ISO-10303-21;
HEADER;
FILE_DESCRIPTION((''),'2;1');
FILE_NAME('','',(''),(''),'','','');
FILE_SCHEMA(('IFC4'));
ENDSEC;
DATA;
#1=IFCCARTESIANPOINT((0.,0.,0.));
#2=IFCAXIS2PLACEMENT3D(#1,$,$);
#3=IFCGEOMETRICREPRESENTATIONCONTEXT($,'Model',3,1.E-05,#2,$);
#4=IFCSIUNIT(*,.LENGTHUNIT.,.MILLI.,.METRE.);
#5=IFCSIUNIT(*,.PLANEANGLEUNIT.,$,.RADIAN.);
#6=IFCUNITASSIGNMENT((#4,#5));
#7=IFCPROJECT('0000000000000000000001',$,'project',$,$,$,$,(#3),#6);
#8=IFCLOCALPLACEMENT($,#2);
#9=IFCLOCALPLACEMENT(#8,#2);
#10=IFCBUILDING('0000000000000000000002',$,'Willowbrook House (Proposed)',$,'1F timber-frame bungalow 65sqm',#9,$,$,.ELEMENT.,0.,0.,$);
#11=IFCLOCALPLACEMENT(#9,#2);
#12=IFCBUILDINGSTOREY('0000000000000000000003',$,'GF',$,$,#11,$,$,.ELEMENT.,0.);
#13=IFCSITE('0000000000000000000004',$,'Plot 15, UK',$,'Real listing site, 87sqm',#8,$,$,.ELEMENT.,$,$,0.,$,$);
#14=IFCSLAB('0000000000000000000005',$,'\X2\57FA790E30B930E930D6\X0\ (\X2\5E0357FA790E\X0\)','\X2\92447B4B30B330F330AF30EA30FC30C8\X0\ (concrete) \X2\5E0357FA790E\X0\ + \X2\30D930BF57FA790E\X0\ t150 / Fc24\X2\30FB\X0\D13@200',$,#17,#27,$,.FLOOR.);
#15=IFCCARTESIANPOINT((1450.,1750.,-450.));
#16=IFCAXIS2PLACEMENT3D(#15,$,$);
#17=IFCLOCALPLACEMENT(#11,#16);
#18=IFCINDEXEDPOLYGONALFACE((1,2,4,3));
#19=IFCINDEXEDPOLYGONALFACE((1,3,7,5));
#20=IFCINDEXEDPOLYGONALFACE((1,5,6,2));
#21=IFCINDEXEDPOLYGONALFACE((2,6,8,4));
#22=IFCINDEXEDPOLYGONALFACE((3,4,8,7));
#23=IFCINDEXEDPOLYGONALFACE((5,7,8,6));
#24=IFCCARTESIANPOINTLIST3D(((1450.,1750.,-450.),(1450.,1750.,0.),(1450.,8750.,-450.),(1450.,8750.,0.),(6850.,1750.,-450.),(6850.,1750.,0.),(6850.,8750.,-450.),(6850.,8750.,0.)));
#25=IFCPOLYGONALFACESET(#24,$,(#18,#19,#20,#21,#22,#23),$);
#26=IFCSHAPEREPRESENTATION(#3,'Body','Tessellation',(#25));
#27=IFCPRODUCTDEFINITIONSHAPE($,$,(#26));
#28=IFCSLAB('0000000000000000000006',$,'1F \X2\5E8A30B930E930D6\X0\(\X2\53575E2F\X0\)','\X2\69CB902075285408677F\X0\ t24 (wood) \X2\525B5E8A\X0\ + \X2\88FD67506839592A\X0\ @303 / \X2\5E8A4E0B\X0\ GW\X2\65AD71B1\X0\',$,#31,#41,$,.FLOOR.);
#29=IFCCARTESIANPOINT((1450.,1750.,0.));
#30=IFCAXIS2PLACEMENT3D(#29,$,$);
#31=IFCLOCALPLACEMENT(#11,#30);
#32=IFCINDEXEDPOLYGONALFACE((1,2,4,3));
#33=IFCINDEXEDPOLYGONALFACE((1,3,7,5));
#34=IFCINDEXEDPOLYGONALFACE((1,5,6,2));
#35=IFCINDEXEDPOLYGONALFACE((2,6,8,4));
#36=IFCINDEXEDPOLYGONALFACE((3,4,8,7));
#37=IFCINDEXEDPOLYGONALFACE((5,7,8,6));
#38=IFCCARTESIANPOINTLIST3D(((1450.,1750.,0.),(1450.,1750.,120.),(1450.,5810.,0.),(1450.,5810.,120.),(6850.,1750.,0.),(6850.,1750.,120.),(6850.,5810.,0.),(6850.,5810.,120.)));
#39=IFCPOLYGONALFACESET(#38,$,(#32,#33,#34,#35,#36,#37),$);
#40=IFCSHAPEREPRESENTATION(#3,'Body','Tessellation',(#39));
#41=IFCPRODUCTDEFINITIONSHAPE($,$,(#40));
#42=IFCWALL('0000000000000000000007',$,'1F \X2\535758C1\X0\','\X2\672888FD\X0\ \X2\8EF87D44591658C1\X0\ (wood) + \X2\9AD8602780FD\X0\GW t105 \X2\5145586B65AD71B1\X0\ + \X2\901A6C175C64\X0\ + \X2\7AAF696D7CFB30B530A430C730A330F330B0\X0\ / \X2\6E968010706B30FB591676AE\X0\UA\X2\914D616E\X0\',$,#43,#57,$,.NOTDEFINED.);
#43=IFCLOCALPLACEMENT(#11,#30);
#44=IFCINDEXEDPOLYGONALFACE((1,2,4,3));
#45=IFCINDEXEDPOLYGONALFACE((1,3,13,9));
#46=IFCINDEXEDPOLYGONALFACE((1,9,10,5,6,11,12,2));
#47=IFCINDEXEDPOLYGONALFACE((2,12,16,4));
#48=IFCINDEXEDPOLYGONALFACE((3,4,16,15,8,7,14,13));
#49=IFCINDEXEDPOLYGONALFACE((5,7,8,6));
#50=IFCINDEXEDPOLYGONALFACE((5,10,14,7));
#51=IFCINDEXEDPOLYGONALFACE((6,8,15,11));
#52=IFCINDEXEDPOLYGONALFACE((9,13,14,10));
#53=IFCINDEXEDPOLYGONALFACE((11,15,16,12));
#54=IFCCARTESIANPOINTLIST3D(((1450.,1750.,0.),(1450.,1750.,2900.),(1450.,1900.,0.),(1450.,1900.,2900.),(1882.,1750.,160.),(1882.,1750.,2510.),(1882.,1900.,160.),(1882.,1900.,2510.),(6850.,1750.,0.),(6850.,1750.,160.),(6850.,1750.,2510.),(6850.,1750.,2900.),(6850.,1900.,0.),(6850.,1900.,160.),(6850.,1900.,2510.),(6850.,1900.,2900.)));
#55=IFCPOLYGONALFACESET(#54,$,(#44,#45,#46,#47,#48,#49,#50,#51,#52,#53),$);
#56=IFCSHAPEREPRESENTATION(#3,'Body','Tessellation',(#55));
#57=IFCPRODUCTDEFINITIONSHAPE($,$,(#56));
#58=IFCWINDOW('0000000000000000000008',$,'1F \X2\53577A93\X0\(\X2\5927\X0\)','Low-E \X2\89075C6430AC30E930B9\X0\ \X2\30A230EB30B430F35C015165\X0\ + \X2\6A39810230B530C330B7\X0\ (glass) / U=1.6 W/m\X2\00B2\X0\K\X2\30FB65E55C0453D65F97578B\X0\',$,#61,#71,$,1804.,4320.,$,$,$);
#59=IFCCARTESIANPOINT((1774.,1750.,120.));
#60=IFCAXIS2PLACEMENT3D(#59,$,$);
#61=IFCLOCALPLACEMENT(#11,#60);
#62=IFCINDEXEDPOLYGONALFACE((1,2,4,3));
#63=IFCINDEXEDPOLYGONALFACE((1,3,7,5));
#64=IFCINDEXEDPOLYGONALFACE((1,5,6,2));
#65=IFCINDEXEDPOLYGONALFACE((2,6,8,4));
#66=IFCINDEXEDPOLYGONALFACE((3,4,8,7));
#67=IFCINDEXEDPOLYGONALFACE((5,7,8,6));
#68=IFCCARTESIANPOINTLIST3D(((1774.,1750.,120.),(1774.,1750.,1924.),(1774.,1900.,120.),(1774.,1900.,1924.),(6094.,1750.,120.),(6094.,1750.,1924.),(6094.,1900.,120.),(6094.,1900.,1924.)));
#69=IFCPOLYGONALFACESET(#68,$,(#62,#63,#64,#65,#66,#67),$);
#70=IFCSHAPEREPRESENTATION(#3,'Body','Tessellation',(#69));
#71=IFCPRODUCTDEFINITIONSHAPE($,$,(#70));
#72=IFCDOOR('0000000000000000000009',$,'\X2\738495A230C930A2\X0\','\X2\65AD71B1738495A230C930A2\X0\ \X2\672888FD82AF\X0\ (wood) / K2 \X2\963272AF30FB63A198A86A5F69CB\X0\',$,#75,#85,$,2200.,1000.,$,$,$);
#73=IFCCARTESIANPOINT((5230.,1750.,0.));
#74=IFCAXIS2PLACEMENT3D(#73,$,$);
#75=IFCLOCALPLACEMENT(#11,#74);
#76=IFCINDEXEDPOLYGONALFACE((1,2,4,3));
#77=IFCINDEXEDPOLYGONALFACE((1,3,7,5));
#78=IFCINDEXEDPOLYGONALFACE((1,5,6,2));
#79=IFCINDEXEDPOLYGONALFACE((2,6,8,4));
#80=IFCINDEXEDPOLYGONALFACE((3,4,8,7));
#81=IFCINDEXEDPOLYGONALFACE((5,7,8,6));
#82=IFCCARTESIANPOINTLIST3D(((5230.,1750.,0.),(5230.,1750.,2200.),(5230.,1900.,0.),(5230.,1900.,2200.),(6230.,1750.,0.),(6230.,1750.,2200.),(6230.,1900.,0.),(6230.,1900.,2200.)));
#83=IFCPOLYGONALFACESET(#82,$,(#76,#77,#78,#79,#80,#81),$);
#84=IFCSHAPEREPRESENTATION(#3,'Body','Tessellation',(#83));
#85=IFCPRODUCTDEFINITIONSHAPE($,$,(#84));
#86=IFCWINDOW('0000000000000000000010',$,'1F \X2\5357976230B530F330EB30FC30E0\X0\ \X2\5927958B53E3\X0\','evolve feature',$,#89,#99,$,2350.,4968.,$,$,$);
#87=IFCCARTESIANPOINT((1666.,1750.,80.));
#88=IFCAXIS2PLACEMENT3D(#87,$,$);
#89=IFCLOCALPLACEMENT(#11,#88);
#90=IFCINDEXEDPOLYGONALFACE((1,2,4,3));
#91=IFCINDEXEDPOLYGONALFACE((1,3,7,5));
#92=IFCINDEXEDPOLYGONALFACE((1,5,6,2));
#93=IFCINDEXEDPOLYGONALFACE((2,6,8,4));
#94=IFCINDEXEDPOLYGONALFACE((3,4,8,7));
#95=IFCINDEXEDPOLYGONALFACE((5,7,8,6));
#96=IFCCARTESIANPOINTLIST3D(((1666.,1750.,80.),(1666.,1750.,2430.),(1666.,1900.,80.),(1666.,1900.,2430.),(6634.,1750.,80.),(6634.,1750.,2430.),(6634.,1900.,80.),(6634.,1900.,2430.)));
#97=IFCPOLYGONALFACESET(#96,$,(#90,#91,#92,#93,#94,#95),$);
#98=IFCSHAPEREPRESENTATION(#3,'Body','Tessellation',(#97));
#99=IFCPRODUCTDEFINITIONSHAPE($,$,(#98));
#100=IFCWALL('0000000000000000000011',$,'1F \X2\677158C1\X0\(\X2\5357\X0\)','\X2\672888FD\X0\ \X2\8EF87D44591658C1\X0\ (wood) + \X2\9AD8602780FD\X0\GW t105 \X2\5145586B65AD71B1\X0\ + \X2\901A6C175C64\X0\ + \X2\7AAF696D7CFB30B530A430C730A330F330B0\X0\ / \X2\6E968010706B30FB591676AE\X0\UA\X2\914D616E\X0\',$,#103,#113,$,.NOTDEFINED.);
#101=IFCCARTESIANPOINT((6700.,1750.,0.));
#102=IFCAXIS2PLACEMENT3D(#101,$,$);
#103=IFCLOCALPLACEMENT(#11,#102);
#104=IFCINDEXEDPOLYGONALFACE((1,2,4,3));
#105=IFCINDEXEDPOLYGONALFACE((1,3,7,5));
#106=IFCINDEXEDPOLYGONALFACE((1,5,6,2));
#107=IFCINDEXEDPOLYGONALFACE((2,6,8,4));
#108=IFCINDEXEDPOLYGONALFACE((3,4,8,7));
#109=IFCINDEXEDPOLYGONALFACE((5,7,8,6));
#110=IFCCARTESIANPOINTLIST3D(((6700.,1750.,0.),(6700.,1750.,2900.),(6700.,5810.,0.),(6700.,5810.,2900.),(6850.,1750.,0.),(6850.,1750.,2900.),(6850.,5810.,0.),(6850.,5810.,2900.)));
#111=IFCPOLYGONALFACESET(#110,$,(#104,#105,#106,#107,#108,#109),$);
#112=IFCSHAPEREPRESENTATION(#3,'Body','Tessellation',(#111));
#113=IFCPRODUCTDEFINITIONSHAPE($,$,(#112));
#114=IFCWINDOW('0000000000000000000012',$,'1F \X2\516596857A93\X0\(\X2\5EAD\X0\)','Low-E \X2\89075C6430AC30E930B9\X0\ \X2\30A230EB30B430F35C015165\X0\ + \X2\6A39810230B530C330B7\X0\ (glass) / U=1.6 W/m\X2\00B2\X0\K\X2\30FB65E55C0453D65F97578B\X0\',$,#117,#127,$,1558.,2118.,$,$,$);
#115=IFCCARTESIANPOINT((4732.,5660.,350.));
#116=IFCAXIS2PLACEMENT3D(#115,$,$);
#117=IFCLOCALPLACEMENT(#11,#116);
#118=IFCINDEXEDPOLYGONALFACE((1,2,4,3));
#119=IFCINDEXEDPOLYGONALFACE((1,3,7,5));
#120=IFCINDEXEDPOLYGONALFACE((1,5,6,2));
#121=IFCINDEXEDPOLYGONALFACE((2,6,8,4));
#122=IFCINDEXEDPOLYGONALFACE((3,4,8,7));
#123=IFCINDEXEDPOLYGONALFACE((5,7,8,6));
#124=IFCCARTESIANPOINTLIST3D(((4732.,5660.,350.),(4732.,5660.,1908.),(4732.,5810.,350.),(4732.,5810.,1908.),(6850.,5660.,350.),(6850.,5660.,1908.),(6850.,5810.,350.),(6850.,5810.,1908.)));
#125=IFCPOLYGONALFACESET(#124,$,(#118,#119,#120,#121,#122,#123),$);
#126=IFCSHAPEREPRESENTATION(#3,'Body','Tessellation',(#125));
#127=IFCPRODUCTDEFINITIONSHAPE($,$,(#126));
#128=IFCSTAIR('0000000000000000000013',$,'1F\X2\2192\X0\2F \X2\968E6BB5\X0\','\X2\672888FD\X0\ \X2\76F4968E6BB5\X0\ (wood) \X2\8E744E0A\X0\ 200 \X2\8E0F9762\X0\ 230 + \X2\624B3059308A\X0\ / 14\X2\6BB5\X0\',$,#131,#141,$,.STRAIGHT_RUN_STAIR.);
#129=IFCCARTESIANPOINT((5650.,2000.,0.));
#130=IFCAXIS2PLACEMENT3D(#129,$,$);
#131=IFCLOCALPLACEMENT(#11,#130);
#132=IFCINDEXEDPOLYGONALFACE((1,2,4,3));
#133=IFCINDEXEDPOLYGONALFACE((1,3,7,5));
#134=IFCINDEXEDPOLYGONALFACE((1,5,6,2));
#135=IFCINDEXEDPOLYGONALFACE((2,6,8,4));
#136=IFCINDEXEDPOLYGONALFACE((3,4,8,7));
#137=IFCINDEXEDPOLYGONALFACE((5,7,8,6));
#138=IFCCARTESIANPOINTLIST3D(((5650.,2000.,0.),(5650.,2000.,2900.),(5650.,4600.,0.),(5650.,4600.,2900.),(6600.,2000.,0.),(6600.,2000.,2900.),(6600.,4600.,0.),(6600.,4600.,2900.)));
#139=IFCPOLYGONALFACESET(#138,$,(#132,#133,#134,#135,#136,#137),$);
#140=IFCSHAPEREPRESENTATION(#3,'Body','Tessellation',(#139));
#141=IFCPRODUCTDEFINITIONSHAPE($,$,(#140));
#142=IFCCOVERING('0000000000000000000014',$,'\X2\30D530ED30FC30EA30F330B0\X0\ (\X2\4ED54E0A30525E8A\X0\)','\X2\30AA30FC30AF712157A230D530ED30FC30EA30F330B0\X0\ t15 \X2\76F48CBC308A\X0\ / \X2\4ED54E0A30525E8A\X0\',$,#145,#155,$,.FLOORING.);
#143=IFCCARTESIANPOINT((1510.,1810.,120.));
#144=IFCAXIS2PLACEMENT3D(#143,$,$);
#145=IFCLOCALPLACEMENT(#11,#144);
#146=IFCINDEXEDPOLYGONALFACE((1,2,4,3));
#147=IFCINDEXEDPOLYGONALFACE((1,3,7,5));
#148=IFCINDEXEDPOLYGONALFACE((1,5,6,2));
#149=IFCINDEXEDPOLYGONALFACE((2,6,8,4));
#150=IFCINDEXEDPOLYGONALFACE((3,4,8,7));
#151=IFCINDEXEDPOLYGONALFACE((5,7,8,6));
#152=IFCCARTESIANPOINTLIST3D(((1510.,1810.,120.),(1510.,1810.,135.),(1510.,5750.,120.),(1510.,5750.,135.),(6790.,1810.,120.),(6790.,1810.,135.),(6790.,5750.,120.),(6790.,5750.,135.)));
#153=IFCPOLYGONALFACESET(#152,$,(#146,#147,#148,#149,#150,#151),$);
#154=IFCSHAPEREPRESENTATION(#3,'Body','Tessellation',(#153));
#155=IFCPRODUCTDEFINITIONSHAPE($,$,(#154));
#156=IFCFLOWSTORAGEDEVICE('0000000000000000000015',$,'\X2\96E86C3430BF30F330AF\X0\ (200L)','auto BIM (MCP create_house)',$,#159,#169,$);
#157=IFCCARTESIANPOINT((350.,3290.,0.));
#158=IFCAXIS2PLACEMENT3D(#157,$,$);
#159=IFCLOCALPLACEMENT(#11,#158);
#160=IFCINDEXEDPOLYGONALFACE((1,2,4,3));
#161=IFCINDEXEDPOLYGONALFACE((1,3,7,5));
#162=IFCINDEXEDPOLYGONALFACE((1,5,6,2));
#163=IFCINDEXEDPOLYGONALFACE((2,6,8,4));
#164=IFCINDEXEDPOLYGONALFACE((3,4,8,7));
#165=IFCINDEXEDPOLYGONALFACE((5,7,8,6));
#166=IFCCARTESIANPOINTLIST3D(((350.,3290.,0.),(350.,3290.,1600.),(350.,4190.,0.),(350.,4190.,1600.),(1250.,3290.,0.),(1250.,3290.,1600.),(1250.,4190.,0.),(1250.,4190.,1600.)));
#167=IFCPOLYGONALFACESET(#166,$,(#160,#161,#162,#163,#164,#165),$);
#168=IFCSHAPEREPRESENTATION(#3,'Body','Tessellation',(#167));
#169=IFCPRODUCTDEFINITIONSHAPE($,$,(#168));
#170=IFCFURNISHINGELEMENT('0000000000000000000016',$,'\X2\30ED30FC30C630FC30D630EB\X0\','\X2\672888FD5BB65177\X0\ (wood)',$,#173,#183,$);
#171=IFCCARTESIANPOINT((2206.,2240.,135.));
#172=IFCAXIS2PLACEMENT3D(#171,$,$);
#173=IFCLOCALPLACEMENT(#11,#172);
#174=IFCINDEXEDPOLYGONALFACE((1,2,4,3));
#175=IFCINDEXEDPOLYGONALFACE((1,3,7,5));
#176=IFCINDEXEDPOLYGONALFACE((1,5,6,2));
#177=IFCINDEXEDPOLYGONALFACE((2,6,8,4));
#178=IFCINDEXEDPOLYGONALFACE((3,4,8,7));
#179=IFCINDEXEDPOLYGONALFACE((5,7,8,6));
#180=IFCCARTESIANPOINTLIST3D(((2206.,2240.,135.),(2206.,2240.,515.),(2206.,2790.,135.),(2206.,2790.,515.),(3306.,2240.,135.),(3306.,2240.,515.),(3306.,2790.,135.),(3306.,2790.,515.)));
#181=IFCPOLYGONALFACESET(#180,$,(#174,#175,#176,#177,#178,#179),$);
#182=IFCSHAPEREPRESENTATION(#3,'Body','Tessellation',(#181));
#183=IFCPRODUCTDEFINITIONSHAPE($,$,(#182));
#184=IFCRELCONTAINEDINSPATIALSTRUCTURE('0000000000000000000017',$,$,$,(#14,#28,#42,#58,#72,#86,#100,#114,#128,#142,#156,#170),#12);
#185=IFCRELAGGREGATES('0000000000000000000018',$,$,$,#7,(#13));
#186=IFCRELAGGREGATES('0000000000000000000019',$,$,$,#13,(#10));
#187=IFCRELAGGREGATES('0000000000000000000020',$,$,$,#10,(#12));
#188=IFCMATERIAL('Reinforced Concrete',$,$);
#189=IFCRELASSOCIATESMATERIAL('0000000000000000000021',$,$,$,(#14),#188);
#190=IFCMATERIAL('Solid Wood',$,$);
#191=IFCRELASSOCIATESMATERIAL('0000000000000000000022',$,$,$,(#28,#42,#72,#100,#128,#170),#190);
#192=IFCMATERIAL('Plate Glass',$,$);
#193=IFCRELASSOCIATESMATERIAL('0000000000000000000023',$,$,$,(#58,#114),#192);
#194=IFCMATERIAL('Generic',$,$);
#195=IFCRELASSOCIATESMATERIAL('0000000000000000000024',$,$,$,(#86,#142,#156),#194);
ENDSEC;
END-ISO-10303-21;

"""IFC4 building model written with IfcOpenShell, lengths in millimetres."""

from ifc_helpers import new_model, si_unit, frame, frame_2d, origin, place, context, project, spatial, rectangle, extrude, material, element, fill, save


model = new_model("IFC4")

# Units and contexts
model_context = context("Model", 3, precision=1e-05, world=origin())
ifc_project = project(units=[si_unit("LENGTHUNIT", "METRE", prefix="MILLI"), si_unit("PLANEANGLEUNIT", "RADIAN")], contexts=[model_context])

# Site, building, storey
site_placement = place(None, origin())
site = spatial("IfcSite", under=ifc_project, at=site_placement, Name="Plot 15, UK", ObjectType="Real listing site, 87sqm", CompositionType="ELEMENT", RefElevation=0.0)
building_placement = place(site_placement, origin())
building = spatial("IfcBuilding", under=site, at=building_placement, Name="Willowbrook House (Proposed)", ObjectType="1F timber-frame bungalow 65sqm", CompositionType="ELEMENT", ElevationOfRefHeight=0.0, ElevationOfTerrain=0.0)
storey_placement = place(building_placement, origin())
storey = spatial("IfcBuildingStorey", under=building, at=storey_placement, Name="GF", CompositionType="ELEMENT", Elevation=0.0)

# Slabs
ifc_material_1 = material(Name="Reinforced Concrete")
slab_1_placement = place(storey_placement, frame((1450.0, 1750.0, -450.0)))
element("IfcSlab", 1, at=slab_1_placement, inside=storey, material=ifc_material_1, Name="基礎スラブ (布基礎)", Description="鉄筋コンクリート (concrete) 布基礎 + ベタ基礎 t150 / Fc24・D13@200", PredefinedType="FLOOR", context=model_context, shape_type="SweptSolid", body=[
    extrude(rectangle(XDim=5400.0, YDim=7000.0, at=frame_2d((2700.0, 3500.0))), frame((1450.0, 1750.0, -450.0)), (0.0, 0.0, 1.0), 450.0),
])
ifc_material_2 = material(Name="Solid Wood")
slab_2_placement = place(storey_placement, frame((1450.0, 1750.0, 0.0)))
element("IfcSlab", 2, at=slab_2_placement, inside=storey, material=ifc_material_2, Name="1F 床スラブ(南帯)", Description="構造用合板 t24 (wood) 剛床 + 製材根太 @303 / 床下 GW断熱", PredefinedType="FLOOR", context=model_context, shape_type="SweptSolid", body=[
    extrude(rectangle(XDim=5400.0, YDim=4060.0, at=frame_2d((2700.0, 2030.0))), frame((1450.0, 1750.0, 0.0)), (0.0, 0.0, 1.0), 120.0),
])

# Wall, openings, windows, door
wall_1_placement = place(storey_placement, frame((1450.0, 1750.0, 0.0)))
wall_1 = element("IfcWall", 3, at=wall_1_placement, inside=storey, material=ifc_material_2, Name="1F 南壁", Description="木製 軸組外壁 (wood) + 高性能GW t105 充填断熱 + 通気層 + 窯業系サイディング / 準耐火・外皮UA配慮", PredefinedType="NOTDEFINED", context=model_context, shape_type="SweptSolid", body=[
    extrude(rectangle(XDim=5400.0, YDim=150.0, at=frame_2d((2700.0, 75.0))), frame((1450.0, 1750.0, 0.0)), (0.0, 0.0, 1.0), 2900.0),
])
opening_1_placement = place(storey_placement, frame((1774.0, 1750.0, 120.0)))
opening_1 = element("IfcOpeningElement", 4, at=opening_1_placement, cuts=wall_1, PredefinedType="NOTDEFINED", context=model_context, shape_type="SweptSolid", body=[
    extrude(rectangle(XDim=4320.0, YDim=150.0, at=frame_2d((2160.0, 75.0))), frame((1774.0, 1750.0, 120.0)), (0.0, 0.0, 1.0), 1804.0),
])
opening_2_placement = place(storey_placement, frame((5230.0, 1750.0, 0.0)))
opening_2 = element("IfcOpeningElement", 5, at=opening_2_placement, cuts=wall_1, PredefinedType="NOTDEFINED", context=model_context, shape_type="SweptSolid", body=[
    extrude(rectangle(XDim=1000.0, YDim=150.0, at=frame_2d((500.0, 75.0))), frame((5230.0, 1750.0, 0.0)), (0.0, 0.0, 1.0), 2200.0),
])
opening_3_placement = place(storey_placement, frame((1666.0, 1750.0, 80.0)))
opening_3 = element("IfcOpeningElement", 6, at=opening_3_placement, cuts=wall_1, PredefinedType="NOTDEFINED", context=model_context, shape_type="SweptSolid", body=[
    extrude(rectangle(XDim=4968.0, YDim=150.0, at=frame_2d((2484.0, 75.0))), frame((1666.0, 1750.0, 80.0)), (0.0, 0.0, 1.0), 2350.0),
])
ifc_material_3 = material(Name="Plate Glass")
window_1_placement = place(storey_placement, frame((1774.0, 1750.0, 120.0)))
window_1 = element("IfcWindow", 7, at=window_1_placement, inside=storey, material=ifc_material_3, Name="1F 南窓(大)", Description="Low-E 複層ガラス アルゴン封入 + 樹脂サッシ (glass) / U=1.6 W/m²K・日射取得型", OverallHeight=1804.0, OverallWidth=4320.0, context=model_context, shape_type="SweptSolid", body=[
    extrude(rectangle(XDim=4320.0, YDim=150.0, at=frame_2d((2160.0, 75.0))), frame((1774.0, 1750.0, 120.0)), (0.0, 0.0, 1.0), 1804.0),
])
fill(opening_1, window_1)
door_1_placement = place(storey_placement, frame((5230.0, 1750.0, 0.0)))
door_1 = element("IfcDoor", 8, at=door_1_placement, inside=storey, material=ifc_material_2, Name="玄関ドア", Description="断熱玄関ドア 木製芯 (wood) / K2 防犯・採風機構", OverallHeight=2200.0, OverallWidth=1000.0, context=model_context, shape_type="SweptSolid", body=[
    extrude(rectangle(XDim=1000.0, YDim=150.0, at=frame_2d((500.0, 75.0))), frame((5230.0, 1750.0, 0.0)), (0.0, 0.0, 1.0), 2200.0),
])
fill(opening_2, door_1)
ifc_material_4 = material(Name="Generic")
window_2_placement = place(storey_placement, frame((1666.0, 1750.0, 80.0)))
window_2 = element("IfcWindow", 9, at=window_2_placement, inside=storey, material=ifc_material_4, Name="1F 南面サンルーム 大開口", Description="evolve feature", OverallHeight=2350.0, OverallWidth=4968.0, context=model_context, shape_type="SweptSolid", body=[
    extrude(rectangle(XDim=4968.0, YDim=150.0, at=frame_2d((2484.0, 75.0))), frame((1666.0, 1750.0, 80.0)), (0.0, 0.0, 1.0), 2350.0),
])
fill(opening_3, window_2)

# Wall, opening, window
wall_2_placement = place(storey_placement, frame((6700.0, 1750.0, 0.0)))
wall_2 = element("IfcWall", 10, at=wall_2_placement, inside=storey, material=ifc_material_2, Name="1F 東壁(南)", Description="木製 軸組外壁 (wood) + 高性能GW t105 充填断熱 + 通気層 + 窯業系サイディング / 準耐火・外皮UA配慮", PredefinedType="NOTDEFINED", context=model_context, shape_type="SweptSolid", body=[
    extrude(rectangle(XDim=150.0, YDim=4060.0, at=frame_2d((75.0, 2030.0))), frame((6700.0, 1750.0, 0.0)), (0.0, 0.0, 1.0), 2900.0),
])
opening_4_placement = place(storey_placement, frame((4732.0, 5660.0, 350.0)))
opening_4 = element("IfcOpeningElement", 11, at=opening_4_placement, cuts=wall_2, PredefinedType="NOTDEFINED", context=model_context, shape_type="SweptSolid", body=[
    extrude(rectangle(XDim=2118.0, YDim=150.0, at=frame_2d((1059.0, 75.0))), frame((4732.0, 5660.0, 350.0)), (0.0, 0.0, 1.0), 1558.0),
])
window_3_placement = place(storey_placement, frame((4732.0, 5660.0, 350.0)))
window_3 = element("IfcWindow", 12, at=window_3_placement, inside=storey, material=ifc_material_3, Name="1F 入隅窓(庭)", Description="Low-E 複層ガラス アルゴン封入 + 樹脂サッシ (glass) / U=1.6 W/m²K・日射取得型", OverallHeight=1558.0, OverallWidth=2118.0, context=model_context, shape_type="SweptSolid", body=[
    extrude(rectangle(XDim=2118.0, YDim=150.0, at=frame_2d((1059.0, 75.0))), frame((4732.0, 5660.0, 350.0)), (0.0, 0.0, 1.0), 1558.0),
])
fill(opening_4, window_3)

# Stair
stair_placement = place(storey_placement, frame((5650.0, 2000.0, 0.0)))
element("IfcStair", 13, at=stair_placement, inside=storey, material=ifc_material_2, Name="1F→2F 階段", Description="木製 直階段 (wood) 蹴上 200 踏面 230 + 手すり / 14段", PredefinedType="STRAIGHT_RUN_STAIR", context=model_context, shape_type="SweptSolid", body=[
    extrude(rectangle(XDim=950.0, YDim=2600.0, at=frame_2d((475.0, 1300.0))), frame((5650.0, 2000.0, 0.0)), (0.0, 0.0, 1.0), 2900.0),
])

# Covering
covering_placement = place(storey_placement, frame((1510.0, 1810.0, 120.0)))
element("IfcCovering", 14, at=covering_placement, inside=storey, material=ifc_material_4, Name="フローリング (仕上げ床)", Description="オーク無垢フローリング t15 直貼り / 仕上げ床", PredefinedType="FLOORING", context=model_context, shape_type="SweptSolid", body=[
    extrude(rectangle(XDim=5280.0, YDim=3940.0, at=frame_2d((2640.0, 1970.0))), frame((1510.0, 1810.0, 120.0)), (0.0, 0.0, 1.0), 15.0),
])

# Flow storage device
flow_storage_device_placement = place(storey_placement, frame((350.0, 3290.0, 0.0)))
element("IfcFlowStorageDevice", 15, at=flow_storage_device_placement, inside=storey, material=ifc_material_4, Name="雨水タンク (200L)", Description="auto BIM (MCP create_house)", context=model_context, shape_type="SweptSolid", body=[
    extrude(rectangle(XDim=900.0, YDim=900.0, at=frame_2d((450.0, 450.0))), frame((350.0, 3290.0, 0.0)), (0.0, 0.0, 1.0), 1600.0),
])

# Furnishing element
furnishing_1_placement = place(storey_placement, frame((2206.0, 2240.0, 135.0)))
element("IfcFurnishingElement", 16, at=furnishing_1_placement, inside=storey, material=ifc_material_2, Name="ローテーブル", Description="木製家具 (wood)", context=model_context, shape_type="SweptSolid", body=[
    extrude(rectangle(XDim=1100.0, YDim=550.0, at=frame_2d((550.0, 275.0))), frame((2206.0, 2240.0, 135.0)), (0.0, 0.0, 1.0), 380.0),
])

save(model, "model.ifc")
